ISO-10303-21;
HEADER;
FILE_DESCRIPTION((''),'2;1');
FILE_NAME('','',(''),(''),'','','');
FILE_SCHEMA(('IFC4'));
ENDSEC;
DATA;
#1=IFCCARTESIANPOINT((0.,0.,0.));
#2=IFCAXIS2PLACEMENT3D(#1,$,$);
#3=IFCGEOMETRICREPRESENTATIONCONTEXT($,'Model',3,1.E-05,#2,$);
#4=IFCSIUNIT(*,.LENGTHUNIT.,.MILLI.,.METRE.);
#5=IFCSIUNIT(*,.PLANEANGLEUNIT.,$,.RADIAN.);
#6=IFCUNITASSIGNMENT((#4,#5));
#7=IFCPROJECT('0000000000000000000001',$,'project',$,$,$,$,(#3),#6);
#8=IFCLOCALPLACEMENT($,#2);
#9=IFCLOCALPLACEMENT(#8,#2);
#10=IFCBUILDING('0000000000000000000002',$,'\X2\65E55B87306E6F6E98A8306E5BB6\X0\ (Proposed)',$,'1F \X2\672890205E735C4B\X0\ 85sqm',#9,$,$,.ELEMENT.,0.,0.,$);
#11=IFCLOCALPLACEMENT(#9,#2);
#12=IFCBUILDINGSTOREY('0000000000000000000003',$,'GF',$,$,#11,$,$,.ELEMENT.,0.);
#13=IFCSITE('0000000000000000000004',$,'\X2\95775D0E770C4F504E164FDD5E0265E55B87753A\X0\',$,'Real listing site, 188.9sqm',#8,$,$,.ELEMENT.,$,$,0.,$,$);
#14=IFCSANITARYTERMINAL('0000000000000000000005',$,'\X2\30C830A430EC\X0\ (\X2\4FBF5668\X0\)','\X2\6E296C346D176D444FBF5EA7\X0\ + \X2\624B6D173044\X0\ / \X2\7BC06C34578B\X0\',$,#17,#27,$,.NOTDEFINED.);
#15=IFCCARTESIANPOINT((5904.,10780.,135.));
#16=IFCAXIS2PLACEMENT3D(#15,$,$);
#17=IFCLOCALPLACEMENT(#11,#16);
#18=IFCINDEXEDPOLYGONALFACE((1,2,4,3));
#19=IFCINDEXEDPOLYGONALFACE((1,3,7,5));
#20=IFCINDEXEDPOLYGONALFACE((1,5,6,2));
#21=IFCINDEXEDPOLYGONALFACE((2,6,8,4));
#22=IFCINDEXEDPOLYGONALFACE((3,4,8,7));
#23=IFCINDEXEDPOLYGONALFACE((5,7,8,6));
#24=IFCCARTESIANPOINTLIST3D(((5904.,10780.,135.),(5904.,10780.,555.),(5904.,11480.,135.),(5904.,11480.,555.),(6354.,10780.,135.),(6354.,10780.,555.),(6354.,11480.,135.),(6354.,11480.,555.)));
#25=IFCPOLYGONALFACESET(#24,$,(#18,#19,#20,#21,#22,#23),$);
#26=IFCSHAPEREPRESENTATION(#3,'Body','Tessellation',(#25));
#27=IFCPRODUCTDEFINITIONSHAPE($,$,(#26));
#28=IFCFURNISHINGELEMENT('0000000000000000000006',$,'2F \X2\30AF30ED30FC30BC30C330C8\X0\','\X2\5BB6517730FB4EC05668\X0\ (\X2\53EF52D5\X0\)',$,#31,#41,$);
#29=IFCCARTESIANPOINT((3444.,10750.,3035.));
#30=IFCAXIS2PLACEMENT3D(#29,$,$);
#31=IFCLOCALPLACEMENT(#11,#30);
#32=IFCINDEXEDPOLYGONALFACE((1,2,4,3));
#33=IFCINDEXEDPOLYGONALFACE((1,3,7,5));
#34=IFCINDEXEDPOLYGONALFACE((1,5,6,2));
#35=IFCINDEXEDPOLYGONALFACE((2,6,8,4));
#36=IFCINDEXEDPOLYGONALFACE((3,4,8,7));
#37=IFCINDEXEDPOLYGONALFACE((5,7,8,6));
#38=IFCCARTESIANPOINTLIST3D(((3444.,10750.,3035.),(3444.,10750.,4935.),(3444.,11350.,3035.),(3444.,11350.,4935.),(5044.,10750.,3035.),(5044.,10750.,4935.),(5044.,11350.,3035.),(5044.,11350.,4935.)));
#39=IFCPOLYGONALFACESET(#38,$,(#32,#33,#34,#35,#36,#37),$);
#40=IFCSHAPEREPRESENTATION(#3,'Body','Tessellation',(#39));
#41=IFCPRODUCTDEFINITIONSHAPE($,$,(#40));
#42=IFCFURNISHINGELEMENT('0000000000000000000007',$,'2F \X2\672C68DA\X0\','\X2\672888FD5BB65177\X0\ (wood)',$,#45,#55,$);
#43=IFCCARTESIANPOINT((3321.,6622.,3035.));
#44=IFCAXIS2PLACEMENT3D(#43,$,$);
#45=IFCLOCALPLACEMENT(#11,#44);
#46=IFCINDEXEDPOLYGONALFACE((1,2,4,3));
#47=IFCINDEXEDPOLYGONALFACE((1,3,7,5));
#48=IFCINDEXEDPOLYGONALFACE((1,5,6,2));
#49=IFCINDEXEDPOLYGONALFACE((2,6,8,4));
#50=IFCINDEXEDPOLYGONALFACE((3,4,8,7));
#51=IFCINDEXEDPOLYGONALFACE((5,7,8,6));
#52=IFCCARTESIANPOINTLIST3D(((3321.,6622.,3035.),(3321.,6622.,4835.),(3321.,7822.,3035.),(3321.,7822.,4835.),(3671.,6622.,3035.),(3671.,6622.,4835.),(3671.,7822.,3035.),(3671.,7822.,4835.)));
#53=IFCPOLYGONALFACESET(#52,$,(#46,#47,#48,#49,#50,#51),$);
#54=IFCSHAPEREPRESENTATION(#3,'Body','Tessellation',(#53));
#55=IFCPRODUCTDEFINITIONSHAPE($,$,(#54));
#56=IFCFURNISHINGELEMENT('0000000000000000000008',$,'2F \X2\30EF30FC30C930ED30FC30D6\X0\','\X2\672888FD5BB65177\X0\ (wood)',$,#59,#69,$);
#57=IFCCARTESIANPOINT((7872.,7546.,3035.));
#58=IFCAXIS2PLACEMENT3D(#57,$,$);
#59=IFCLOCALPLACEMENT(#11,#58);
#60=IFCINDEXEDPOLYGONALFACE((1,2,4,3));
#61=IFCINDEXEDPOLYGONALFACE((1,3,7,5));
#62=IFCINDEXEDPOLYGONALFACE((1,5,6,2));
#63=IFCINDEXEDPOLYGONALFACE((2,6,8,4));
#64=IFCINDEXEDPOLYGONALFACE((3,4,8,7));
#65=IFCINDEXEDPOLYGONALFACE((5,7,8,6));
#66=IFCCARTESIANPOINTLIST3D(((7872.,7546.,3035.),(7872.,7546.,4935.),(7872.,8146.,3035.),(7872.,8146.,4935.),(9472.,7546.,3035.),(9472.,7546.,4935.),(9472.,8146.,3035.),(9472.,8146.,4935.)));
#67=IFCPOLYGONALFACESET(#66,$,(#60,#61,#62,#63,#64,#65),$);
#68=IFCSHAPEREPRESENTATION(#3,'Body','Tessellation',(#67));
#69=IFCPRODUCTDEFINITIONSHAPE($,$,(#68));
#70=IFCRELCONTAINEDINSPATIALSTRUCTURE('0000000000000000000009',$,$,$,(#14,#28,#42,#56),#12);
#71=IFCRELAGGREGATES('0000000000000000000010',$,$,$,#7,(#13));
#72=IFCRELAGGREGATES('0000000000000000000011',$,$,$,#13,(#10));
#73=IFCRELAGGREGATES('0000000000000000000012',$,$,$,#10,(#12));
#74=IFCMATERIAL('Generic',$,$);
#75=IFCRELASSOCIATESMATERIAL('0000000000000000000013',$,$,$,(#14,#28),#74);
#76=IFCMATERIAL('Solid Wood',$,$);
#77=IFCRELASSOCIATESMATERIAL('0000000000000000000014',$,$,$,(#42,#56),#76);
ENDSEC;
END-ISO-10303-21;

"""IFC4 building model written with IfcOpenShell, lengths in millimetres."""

from ifc_helpers import new_model, si_unit, frame, frame_2d, origin, place, context, project, spatial, rectangle, extrude, material, element, save


model = new_model("IFC4")

# Units and contexts
model_context = context("Model", 3, precision=1e-05, world=origin())
ifc_project = project(units=[si_unit("LENGTHUNIT", "METRE", prefix="MILLI"), si_unit("PLANEANGLEUNIT", "RADIAN")], contexts=[model_context])

# Site, building, storey
site_placement = place(None, origin())
site = spatial("IfcSite", under=ifc_project, at=site_placement, Name="長崎県佐世保市日宇町", ObjectType="Real listing site, 188.9sqm", CompositionType="ELEMENT", RefElevation=0.0)
building_placement = place(site_placement, origin())
building = spatial("IfcBuilding", under=site, at=building_placement, Name="日宇の潮風の家 (Proposed)", ObjectType="1F 木造平屋 85sqm", CompositionType="ELEMENT", ElevationOfRefHeight=0.0, ElevationOfTerrain=0.0)
storey_placement = place(building_placement, origin())
storey = spatial("IfcBuildingStorey", under=building, at=storey_placement, Name="GF", CompositionType="ELEMENT", Elevation=0.0)

# Shared definitions
ifc_material_1 = material(Name="Solid Wood")

# Shared definitions
ifc_material_2 = material(Name="Generic")

# Sanitary terminal
sanitary_terminal_placement = place(storey_placement, frame((5904.0, 10780.0, 135.0)))
element("IfcSanitaryTerminal", 1, at=sanitary_terminal_placement, inside=storey, material=ifc_material_2, Name="トイレ (便器)", Description="温水洗浄便座 + 手洗い / 節水型", PredefinedType="NOTDEFINED", context=model_context, shape_type="SweptSolid", body=[
    extrude(rectangle(XDim=450.0, YDim=700.0, at=frame_2d((225.0, 350.0))), frame((5904.0, 10780.0, 135.0)), (0.0, 0.0, 1.0), 420.0),
])

# Furnishing elements
furnishing_1_placement = place(storey_placement, frame((3444.0, 10750.0, 3035.0)))
element("IfcFurnishingElement", 2, at=furnishing_1_placement, inside=storey, material=ifc_material_2, Name="2F クローゼット", Description="家具・什器 (可動)", context=model_context, shape_type="SweptSolid", body=[
    extrude(rectangle(XDim=1600.0, YDim=600.0, at=frame_2d((800.0, 300.0))), frame((3444.0, 10750.0, 3035.0)), (0.0, 0.0, 1.0), 1900.0),
])
furnishing_2_placement = place(storey_placement, frame((3321.0, 6622.0, 3035.0)))
element("IfcFurnishingElement", 3, at=furnishing_2_placement, inside=storey, material=ifc_material_1, Name="2F 本棚", Description="木製家具 (wood)", context=model_context, shape_type="SweptSolid", body=[
    extrude(rectangle(XDim=350.0, YDim=1200.0, at=frame_2d((175.0, 600.0))), frame((3321.0, 6622.0, 3035.0)), (0.0, 0.0, 1.0), 1800.0),
])
furnishing_3_placement = place(storey_placement, frame((7872.0, 7546.0, 3035.0)))
element("IfcFurnishingElement", 4, at=furnishing_3_placement, inside=storey, material=ifc_material_1, Name="2F ワードローブ", Description="木製家具 (wood)", context=model_context, shape_type="SweptSolid", body=[
    extrude(rectangle(XDim=1600.0, YDim=600.0, at=frame_2d((800.0, 300.0))), frame((7872.0, 7546.0, 3035.0)), (0.0, 0.0, 1.0), 1900.0),
])

save(model, "model.ifc")
